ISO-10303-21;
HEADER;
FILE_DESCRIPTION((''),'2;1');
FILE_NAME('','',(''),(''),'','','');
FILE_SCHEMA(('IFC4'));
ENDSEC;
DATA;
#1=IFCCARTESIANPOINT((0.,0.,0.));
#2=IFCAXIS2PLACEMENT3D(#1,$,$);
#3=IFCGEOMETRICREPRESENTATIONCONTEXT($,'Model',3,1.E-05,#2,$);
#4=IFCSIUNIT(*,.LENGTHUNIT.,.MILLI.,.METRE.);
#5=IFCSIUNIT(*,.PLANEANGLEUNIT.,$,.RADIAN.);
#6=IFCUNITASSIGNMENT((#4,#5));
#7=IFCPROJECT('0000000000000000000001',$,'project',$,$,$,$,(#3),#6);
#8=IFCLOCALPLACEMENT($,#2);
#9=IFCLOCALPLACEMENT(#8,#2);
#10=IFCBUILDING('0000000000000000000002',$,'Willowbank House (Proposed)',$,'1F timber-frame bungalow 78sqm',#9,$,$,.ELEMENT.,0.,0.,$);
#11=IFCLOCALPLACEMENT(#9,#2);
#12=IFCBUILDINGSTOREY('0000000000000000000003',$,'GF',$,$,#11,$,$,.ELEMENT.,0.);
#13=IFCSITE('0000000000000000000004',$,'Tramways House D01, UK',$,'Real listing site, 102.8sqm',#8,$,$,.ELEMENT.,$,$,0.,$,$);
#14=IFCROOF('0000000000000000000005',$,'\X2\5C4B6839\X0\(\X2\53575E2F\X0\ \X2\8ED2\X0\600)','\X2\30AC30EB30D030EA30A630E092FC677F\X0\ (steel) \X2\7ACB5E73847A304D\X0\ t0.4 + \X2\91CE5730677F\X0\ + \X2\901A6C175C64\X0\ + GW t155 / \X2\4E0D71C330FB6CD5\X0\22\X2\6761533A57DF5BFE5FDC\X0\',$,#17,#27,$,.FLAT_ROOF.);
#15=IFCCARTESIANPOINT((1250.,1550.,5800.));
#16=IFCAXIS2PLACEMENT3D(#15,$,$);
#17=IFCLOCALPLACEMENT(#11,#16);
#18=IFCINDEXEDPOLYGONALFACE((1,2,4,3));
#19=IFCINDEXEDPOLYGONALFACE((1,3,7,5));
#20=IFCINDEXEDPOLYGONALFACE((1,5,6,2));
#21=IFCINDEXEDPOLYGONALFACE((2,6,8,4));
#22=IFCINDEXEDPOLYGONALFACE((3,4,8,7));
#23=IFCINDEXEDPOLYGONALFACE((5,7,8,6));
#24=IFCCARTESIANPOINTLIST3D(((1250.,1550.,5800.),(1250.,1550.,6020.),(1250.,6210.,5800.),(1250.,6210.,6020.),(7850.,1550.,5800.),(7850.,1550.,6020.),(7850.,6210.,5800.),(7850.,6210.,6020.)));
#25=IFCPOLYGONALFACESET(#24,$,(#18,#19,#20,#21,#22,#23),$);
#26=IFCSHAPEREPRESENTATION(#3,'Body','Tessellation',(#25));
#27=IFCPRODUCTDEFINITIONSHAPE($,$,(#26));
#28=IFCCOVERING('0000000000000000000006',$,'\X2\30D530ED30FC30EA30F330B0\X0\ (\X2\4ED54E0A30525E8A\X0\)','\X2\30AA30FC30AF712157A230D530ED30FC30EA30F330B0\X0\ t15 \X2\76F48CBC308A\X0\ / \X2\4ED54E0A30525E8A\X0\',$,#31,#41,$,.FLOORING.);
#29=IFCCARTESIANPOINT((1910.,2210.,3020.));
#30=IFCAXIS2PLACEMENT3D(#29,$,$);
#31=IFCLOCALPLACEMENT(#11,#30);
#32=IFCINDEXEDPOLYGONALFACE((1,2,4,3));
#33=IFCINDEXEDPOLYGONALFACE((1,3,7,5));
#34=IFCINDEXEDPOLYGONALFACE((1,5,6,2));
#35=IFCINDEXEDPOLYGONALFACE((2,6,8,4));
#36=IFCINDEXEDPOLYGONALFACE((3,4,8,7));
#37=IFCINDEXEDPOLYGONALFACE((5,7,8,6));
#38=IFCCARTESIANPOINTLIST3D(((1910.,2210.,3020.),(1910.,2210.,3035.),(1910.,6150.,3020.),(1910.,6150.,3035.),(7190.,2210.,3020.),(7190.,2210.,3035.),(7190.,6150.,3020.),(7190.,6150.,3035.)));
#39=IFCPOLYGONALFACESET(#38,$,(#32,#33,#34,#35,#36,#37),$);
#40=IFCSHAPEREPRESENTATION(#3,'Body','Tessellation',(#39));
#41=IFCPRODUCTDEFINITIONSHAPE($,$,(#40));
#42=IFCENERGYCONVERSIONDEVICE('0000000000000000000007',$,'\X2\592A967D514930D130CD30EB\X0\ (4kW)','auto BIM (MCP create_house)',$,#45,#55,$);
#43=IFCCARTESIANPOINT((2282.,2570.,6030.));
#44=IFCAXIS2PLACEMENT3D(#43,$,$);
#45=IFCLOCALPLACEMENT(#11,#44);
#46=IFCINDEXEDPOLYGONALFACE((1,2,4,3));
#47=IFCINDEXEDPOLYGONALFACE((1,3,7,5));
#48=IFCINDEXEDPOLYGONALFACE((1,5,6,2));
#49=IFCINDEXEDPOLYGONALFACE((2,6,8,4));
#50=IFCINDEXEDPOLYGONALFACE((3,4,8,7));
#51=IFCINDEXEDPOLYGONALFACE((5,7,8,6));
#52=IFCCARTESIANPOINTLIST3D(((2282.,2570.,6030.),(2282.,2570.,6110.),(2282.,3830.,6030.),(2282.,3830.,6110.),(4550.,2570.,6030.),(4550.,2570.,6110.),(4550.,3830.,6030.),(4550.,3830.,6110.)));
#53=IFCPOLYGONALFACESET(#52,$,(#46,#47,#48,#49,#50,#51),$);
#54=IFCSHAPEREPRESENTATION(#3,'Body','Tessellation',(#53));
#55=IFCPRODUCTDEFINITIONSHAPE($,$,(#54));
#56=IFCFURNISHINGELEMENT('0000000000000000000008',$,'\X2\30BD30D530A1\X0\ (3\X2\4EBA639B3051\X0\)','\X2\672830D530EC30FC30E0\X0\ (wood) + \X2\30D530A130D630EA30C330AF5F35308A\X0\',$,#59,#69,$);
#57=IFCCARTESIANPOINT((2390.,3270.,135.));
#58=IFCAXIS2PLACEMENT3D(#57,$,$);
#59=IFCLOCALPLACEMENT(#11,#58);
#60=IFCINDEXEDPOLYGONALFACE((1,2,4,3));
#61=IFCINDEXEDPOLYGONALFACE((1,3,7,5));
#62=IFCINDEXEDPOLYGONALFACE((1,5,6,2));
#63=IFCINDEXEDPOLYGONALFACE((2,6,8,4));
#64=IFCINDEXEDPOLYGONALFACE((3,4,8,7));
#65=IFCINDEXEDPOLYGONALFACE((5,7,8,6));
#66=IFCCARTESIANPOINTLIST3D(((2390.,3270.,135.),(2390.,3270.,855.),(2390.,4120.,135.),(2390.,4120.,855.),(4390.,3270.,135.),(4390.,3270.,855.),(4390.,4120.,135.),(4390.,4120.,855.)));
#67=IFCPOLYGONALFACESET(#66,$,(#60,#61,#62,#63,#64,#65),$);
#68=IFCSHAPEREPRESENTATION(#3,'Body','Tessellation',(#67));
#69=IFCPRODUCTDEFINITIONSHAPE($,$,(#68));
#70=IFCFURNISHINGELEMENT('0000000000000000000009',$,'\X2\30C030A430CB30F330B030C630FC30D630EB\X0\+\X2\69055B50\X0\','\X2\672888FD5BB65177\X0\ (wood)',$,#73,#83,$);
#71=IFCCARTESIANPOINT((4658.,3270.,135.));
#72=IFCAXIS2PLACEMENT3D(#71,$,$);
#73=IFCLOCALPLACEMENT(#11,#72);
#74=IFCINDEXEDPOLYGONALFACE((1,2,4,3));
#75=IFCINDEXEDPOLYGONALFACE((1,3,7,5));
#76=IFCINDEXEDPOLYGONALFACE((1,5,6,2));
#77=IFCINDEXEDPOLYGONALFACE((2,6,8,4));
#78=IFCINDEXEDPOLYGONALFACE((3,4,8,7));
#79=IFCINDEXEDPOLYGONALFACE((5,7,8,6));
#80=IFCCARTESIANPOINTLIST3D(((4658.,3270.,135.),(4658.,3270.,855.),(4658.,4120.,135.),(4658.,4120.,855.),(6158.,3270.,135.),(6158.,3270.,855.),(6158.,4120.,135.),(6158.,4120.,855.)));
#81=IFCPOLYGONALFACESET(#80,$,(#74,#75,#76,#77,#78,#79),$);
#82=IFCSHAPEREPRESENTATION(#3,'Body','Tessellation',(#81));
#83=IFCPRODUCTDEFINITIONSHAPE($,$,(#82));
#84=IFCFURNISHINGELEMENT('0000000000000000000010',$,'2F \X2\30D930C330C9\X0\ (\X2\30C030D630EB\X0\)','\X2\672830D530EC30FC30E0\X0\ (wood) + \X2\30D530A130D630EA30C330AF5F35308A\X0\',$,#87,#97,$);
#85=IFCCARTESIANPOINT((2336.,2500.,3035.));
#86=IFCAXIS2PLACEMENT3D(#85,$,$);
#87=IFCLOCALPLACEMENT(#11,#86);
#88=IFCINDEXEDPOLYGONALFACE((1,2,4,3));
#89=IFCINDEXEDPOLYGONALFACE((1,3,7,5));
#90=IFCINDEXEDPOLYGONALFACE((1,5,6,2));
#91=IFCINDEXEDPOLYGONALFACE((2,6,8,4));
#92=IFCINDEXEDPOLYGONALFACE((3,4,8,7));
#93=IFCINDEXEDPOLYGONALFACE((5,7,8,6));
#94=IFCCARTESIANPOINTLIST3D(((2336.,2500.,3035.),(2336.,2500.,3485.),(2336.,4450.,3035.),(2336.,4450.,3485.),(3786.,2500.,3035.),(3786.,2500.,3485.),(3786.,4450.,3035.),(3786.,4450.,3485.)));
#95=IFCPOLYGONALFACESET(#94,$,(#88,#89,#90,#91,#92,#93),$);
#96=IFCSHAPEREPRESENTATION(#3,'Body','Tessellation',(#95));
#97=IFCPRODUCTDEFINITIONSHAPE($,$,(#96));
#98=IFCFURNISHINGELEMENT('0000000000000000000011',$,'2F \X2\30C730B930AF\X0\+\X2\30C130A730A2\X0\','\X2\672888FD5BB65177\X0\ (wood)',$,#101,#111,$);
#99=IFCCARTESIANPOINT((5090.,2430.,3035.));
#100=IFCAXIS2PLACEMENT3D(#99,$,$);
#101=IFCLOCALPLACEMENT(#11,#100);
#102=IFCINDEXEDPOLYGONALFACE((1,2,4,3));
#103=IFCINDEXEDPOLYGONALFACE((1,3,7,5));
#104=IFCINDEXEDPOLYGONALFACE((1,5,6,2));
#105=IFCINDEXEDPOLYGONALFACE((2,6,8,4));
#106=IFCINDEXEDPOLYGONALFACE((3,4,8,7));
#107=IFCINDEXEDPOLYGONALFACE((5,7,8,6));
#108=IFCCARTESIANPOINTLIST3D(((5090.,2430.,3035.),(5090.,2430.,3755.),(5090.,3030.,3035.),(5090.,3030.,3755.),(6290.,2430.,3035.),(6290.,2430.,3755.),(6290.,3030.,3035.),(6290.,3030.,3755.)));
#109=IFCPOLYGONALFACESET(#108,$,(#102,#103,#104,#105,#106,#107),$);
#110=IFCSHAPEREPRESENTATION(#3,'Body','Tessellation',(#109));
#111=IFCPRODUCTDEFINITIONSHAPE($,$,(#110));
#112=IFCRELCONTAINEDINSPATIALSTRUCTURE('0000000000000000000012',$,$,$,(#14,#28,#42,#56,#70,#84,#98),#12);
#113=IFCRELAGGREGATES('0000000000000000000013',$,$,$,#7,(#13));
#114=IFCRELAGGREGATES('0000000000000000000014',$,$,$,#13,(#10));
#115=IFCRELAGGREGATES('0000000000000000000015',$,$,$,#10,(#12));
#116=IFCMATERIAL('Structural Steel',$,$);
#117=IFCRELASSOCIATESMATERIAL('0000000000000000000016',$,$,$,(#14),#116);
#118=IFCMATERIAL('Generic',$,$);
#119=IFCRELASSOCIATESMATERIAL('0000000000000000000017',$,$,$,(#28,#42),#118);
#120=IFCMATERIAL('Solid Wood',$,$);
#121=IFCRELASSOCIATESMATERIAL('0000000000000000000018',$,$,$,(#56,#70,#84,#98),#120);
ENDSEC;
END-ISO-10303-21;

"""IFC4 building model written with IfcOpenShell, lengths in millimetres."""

from ifc_helpers import new_model, si_unit, frame, frame_2d, origin, place, context, project, spatial, rectangle, extrude, material, element, save


model = new_model("IFC4")

# Units and contexts
model_context = context("Model", 3, precision=1e-05, world=origin())
ifc_project = project(units=[si_unit("LENGTHUNIT", "METRE", prefix="MILLI"), si_unit("PLANEANGLEUNIT", "RADIAN")], contexts=[model_context])

# Site, building, storey
site_placement = place(None, origin())
site = spatial("IfcSite", under=ifc_project, at=site_placement, Name="Tramways House D01, UK", ObjectType="Real listing site, 102.8sqm", CompositionType="ELEMENT", RefElevation=0.0)
building_placement = place(site_placement, origin())
building = spatial("IfcBuilding", under=site, at=building_placement, Name="Willowbank House (Proposed)", ObjectType="1F timber-frame bungalow 78sqm", CompositionType="ELEMENT", ElevationOfRefHeight=0.0, ElevationOfTerrain=0.0)
storey_placement = place(building_placement, origin())
storey = spatial("IfcBuildingStorey", under=building, at=storey_placement, Name="GF", CompositionType="ELEMENT", Elevation=0.0)

# Shared definitions
ifc_material_1 = material(Name="Solid Wood")

# Shared definitions
ifc_material_2 = material(Name="Generic")

# Roof
ifc_material_3 = material(Name="Structural Steel")
for number, where, name in (
    (1, (1250.0, 1550.0, 5800.0), "屋根(南帯 軒600)"),
):
    element("IfcRoof", number, at=place(storey_placement, frame(where)), inside=storey, material=ifc_material_3, Name=name, Description="ガルバリウム鋼板 (steel) 立平葺き t0.4 + 野地板 + 通気層 + GW t155 / 不燃・法22条区域対応", PredefinedType="FLAT_ROOF", context=model_context, shape_type="SweptSolid", body=[
        extrude(rectangle(XDim=6600.0, YDim=4660.0, at=frame_2d((3300.0, 2330.0))), frame((1250.0, 1550.0, 5800.0)), (0.0, 0.0, 1.0), 220.0),
    ])

# Covering
covering_placement = place(storey_placement, frame((1910.0, 2210.0, 3020.0)))
element("IfcCovering", 2, at=covering_placement, inside=storey, material=ifc_material_2, Name="フローリング (仕上げ床)", Description="オーク無垢フローリング t15 直貼り / 仕上げ床", PredefinedType="FLOORING", context=model_context, shape_type="SweptSolid", body=[
    extrude(rectangle(XDim=5280.0, YDim=3940.0, at=frame_2d((2640.0, 1970.0))), frame((1910.0, 2210.0, 3020.0)), (0.0, 0.0, 1.0), 15.0),
])

# Energy conversion device
energy_conversion_device_placement = place(storey_placement, frame((2282.0, 2570.0, 6030.0)))
element("IfcEnergyConversionDevice", 3, at=energy_conversion_device_placement, inside=storey, material=ifc_material_2, Name="太陽光パネル (4kW)", Description="auto BIM (MCP create_house)", context=model_context, shape_type="SweptSolid", body=[
    extrude(rectangle(XDim=2268.0, YDim=1260.0, at=frame_2d((1134.0, 630.0))), frame((2282.0, 2570.0, 6030.0)), (0.0, 0.0, 1.0), 80.0),
])

# Furnishing elements
furnishing_1_placement = place(storey_placement, frame((2390.0, 3270.0, 135.0)))
element("IfcFurnishingElement", 4, at=furnishing_1_placement, inside=storey, material=ifc_material_1, Name="ソファ (3人掛け)", Description="木フレーム (wood) + ファブリック張り", context=model_context, shape_type="SweptSolid", body=[
    extrude(rectangle(XDim=2000.0, YDim=850.0, at=frame_2d((1000.0, 425.0))), frame((2390.0, 3270.0, 135.0)), (0.0, 0.0, 1.0), 720.0),
])
furnishing_2_placement = place(storey_placement, frame((4658.0, 3270.0, 135.0)))
element("IfcFurnishingElement", 5, at=furnishing_2_placement, inside=storey, material=ifc_material_1, Name="ダイニングテーブル+椅子", Description="木製家具 (wood)", context=model_context, shape_type="SweptSolid", body=[
    extrude(rectangle(XDim=1500.0, YDim=850.0, at=frame_2d((750.0, 425.0))), frame((4658.0, 3270.0, 135.0)), (0.0, 0.0, 1.0), 720.0),
])
furnishing_3_placement = place(storey_placement, frame((2336.0, 2500.0, 3035.0)))
element("IfcFurnishingElement", 6, at=furnishing_3_placement, inside=storey, material=ifc_material_1, Name="2F ベッド (ダブル)", Description="木フレーム (wood) + ファブリック張り", context=model_context, shape_type="SweptSolid", body=[
    extrude(rectangle(XDim=1450.0, YDim=1950.0, at=frame_2d((725.0, 975.0))), frame((2336.0, 2500.0, 3035.0)), (0.0, 0.0, 1.0), 450.0),
])
furnishing_4_placement = place(storey_placement, frame((5090.0, 2430.0, 3035.0)))
element("IfcFurnishingElement", 7, at=furnishing_4_placement, inside=storey, material=ifc_material_1, Name="2F デスク+チェア", Description="木製家具 (wood)", context=model_context, shape_type="SweptSolid", body=[
    extrude(rectangle(XDim=1200.0, YDim=600.0, at=frame_2d((600.0, 300.0))), frame((5090.0, 2430.0, 3035.0)), (0.0, 0.0, 1.0), 720.0),
])

save(model, "model.ifc")
